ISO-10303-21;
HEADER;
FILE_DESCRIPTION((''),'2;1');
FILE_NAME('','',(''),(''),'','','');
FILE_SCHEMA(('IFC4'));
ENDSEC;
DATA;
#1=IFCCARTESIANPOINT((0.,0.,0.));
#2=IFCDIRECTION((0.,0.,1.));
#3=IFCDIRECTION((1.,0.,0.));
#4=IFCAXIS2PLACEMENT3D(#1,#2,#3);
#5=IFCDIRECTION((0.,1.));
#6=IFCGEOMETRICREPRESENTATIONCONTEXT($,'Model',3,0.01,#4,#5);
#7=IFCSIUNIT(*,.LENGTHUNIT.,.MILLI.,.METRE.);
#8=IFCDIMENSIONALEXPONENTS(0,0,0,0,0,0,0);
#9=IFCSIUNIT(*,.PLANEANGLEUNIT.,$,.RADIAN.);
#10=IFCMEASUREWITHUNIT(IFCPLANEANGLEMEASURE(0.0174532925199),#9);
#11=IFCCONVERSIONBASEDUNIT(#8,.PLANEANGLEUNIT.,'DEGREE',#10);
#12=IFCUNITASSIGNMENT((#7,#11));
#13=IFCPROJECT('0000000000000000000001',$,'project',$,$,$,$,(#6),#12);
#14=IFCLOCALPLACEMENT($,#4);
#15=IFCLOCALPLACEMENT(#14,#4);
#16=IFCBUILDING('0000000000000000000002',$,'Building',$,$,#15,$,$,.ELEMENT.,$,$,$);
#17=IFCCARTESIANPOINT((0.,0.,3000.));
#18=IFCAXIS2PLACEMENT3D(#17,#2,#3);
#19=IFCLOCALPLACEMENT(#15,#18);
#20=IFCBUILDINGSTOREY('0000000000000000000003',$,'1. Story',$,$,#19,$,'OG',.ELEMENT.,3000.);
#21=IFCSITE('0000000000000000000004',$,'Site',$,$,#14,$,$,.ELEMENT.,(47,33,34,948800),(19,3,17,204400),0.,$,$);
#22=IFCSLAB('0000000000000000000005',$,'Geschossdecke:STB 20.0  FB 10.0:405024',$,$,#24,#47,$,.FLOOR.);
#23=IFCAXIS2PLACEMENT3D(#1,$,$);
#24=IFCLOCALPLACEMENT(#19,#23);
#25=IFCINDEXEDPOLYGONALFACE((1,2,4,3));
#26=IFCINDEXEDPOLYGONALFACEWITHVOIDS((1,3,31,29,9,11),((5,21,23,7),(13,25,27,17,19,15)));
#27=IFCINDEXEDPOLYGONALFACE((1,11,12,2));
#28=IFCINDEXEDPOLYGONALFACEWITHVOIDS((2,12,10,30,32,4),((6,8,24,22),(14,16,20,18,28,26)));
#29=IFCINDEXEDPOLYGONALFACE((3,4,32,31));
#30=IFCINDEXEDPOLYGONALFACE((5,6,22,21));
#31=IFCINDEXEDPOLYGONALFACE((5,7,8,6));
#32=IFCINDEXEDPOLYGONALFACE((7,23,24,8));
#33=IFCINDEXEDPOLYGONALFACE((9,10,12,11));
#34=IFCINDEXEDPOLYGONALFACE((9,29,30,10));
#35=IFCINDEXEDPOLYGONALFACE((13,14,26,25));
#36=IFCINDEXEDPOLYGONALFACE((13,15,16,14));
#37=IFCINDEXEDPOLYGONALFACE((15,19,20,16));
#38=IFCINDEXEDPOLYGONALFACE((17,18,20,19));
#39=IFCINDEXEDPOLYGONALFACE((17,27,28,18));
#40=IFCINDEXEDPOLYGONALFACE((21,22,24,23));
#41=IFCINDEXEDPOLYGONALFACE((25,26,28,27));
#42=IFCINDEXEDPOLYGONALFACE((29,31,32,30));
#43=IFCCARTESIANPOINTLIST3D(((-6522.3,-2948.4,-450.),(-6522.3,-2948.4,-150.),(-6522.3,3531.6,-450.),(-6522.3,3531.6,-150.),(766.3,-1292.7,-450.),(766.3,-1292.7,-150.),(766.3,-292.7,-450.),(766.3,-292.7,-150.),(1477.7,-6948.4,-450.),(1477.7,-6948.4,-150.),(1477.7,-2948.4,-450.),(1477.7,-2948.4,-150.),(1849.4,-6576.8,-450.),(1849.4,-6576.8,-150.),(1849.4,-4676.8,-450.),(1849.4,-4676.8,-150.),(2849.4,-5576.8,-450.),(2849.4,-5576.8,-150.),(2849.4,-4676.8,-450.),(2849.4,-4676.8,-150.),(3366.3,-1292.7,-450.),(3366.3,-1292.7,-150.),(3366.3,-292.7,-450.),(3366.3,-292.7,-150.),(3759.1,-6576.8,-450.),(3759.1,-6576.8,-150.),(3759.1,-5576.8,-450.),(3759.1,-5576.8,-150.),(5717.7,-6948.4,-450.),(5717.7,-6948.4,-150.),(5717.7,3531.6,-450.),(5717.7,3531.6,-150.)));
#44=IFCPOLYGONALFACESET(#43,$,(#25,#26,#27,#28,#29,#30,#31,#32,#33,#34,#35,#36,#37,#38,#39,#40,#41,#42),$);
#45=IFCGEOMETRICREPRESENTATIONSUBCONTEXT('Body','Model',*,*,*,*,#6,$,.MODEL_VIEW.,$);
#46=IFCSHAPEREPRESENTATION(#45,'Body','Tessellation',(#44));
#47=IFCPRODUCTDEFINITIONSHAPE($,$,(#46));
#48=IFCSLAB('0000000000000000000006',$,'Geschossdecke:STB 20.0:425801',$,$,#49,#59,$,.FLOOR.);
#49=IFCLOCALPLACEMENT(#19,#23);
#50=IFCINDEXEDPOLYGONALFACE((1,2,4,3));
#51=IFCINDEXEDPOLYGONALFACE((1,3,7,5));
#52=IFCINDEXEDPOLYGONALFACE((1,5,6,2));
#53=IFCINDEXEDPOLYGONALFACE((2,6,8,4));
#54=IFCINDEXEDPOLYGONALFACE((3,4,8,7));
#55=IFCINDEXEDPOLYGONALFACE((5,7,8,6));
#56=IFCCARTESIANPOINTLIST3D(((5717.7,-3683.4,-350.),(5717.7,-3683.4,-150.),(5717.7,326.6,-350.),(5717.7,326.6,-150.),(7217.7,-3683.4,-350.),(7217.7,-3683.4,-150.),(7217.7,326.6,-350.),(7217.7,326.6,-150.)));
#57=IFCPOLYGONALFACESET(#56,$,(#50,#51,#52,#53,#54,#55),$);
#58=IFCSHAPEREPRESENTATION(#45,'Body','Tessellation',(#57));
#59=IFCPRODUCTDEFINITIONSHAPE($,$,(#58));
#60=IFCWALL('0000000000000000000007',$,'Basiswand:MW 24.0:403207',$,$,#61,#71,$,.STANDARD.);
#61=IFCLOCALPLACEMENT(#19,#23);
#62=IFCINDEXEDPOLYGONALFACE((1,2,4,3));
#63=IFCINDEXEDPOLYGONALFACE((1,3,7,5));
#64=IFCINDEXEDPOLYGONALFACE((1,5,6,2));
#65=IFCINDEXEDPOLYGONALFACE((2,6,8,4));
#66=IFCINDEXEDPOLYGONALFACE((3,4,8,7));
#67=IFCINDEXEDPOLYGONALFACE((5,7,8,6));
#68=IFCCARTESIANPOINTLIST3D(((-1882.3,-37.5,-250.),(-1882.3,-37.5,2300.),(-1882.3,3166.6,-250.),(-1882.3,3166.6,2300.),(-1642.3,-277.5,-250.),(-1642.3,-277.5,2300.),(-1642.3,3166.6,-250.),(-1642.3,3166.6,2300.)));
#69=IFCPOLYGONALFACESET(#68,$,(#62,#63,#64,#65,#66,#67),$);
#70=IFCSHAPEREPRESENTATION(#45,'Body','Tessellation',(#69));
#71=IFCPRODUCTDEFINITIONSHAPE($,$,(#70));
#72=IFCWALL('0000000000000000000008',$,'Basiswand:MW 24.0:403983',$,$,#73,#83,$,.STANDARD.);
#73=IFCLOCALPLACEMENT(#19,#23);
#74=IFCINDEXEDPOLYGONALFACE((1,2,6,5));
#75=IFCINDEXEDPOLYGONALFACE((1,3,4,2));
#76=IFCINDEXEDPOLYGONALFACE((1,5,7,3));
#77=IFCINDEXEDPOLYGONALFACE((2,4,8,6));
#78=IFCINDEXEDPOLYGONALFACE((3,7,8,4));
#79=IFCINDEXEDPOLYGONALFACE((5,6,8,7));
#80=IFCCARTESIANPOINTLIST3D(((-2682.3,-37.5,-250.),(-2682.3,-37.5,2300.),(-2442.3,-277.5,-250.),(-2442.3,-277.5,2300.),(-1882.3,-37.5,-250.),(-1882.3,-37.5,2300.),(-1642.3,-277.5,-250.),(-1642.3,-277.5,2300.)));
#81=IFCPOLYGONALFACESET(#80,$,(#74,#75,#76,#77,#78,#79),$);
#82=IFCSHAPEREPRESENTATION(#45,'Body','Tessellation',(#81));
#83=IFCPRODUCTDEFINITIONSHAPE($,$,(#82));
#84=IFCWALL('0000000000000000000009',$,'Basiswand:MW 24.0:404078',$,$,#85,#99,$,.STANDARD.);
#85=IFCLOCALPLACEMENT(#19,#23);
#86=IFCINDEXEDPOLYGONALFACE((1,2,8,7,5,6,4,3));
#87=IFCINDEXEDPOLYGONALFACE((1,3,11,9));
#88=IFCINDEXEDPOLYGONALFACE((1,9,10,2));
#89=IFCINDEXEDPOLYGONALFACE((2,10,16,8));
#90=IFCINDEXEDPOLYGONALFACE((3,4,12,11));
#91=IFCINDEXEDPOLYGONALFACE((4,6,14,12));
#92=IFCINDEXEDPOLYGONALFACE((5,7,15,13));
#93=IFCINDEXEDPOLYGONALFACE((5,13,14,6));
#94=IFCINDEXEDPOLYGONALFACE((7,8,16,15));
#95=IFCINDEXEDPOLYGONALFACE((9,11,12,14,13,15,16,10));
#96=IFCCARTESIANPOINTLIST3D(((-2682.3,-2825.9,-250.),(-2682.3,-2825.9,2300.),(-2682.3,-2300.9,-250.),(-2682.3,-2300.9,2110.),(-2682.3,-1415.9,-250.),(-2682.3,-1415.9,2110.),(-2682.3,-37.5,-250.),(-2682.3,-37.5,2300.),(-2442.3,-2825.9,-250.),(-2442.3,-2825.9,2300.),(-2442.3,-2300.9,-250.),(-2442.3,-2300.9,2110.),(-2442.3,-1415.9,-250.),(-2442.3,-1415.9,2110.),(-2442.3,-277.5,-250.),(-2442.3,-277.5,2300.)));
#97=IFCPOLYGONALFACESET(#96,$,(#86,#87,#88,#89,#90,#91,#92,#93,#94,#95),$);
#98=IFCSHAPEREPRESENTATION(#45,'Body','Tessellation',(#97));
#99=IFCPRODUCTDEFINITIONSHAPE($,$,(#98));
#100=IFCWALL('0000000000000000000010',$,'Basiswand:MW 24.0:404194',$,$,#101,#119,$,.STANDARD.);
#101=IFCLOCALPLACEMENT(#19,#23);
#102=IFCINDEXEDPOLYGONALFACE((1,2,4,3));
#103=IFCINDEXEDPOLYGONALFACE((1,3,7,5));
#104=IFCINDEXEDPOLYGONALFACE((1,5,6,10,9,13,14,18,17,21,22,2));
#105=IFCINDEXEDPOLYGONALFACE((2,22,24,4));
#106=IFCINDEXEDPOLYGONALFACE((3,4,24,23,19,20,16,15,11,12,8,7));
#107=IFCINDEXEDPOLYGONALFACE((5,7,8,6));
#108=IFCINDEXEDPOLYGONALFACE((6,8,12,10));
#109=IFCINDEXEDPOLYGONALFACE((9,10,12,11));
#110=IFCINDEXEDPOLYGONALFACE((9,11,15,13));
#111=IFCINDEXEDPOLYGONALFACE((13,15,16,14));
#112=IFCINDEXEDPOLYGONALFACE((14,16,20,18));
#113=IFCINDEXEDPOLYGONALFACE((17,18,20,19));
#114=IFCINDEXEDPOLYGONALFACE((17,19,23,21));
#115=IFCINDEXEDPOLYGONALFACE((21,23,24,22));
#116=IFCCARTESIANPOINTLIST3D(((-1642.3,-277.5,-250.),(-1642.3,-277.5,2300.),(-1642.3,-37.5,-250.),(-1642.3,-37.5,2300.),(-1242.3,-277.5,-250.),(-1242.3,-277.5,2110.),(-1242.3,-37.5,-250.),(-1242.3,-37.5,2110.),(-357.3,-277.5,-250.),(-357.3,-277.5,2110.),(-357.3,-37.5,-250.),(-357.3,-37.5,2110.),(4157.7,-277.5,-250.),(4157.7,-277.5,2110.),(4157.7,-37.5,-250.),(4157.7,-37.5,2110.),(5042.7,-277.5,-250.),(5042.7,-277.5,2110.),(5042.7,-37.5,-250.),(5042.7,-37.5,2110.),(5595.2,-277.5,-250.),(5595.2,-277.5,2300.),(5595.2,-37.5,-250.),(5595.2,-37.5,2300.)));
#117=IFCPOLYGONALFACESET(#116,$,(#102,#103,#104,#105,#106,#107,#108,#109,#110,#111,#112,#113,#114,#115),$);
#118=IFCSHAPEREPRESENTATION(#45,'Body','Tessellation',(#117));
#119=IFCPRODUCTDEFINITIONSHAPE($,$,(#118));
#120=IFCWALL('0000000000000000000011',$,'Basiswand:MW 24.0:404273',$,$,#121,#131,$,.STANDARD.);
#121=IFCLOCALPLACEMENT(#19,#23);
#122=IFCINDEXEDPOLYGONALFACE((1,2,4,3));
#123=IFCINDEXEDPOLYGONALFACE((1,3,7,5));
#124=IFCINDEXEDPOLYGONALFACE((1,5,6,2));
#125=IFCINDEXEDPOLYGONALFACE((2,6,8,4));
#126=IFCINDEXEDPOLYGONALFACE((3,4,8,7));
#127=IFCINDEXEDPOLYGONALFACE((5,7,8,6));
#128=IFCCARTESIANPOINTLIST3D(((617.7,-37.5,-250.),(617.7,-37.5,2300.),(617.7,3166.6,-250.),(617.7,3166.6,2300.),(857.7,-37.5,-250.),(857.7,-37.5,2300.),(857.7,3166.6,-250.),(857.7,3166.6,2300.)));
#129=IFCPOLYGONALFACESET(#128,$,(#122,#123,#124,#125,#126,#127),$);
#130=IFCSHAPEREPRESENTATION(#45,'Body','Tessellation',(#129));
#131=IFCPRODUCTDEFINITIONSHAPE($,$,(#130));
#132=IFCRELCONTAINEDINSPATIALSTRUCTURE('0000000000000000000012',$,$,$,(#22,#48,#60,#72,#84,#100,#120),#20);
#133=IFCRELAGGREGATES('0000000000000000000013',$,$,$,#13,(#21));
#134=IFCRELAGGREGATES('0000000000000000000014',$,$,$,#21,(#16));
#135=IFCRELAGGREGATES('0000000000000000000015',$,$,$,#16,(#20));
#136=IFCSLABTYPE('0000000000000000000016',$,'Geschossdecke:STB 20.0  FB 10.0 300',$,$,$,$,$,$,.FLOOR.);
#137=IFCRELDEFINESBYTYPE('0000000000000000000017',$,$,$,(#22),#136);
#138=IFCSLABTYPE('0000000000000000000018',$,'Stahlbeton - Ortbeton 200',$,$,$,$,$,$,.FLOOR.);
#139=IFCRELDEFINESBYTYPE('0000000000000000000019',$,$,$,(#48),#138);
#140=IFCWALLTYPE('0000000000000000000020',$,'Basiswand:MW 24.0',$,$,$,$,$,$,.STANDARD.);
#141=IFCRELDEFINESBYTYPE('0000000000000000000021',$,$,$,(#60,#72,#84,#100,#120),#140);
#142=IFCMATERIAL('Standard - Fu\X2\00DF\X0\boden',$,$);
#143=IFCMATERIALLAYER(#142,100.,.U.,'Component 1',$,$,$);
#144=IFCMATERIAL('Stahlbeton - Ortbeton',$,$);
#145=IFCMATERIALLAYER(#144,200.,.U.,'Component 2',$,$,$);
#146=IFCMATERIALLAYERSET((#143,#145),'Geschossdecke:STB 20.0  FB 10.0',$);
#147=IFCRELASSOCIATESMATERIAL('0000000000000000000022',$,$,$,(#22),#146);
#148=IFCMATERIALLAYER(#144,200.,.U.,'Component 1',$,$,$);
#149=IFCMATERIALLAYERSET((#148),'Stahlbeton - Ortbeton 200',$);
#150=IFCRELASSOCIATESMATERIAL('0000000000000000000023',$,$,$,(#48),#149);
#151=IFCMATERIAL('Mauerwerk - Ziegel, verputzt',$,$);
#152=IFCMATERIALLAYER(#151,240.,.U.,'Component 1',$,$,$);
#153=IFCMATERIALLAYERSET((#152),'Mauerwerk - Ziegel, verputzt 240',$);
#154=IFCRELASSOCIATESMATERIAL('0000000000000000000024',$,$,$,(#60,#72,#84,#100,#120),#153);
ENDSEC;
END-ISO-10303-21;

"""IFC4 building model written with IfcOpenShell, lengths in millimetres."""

from ifc_helpers import new_model, entity, si_unit, converted_unit, direction, frame, origin_with_axes, origin_2d_with_axis, place, context, subcontext, project, spatial, line, indexed_curve, rectangle, outline, extrude, material, layer, layer_set, layer_usage, type_object, element, save


model = new_model("IFC4")

# Units and contexts
model_context = context("Model", 3, precision=0.01, world=origin_with_axes(), true_north=direction((0.0, 1.0)))
body_context = subcontext(model_context, "Body", "Model", "MODEL_VIEW")
ifc_project = project(units=[si_unit("LENGTHUNIT", "METRE", prefix="MILLI"), converted_unit("PLANEANGLEUNIT", "DEGREE", entity("IfcPlaneAngleMeasure", 0.0174532925199), si_unit("PLANEANGLEUNIT", "RADIAN"), dimensions=[0, 0, 0, 0, 0, 0, 0])], contexts=[model_context])

# Site, building, storey
site_placement = place(None, origin_with_axes())
site = spatial("IfcSite", under=ifc_project, at=site_placement, Name="Site", CompositionType="ELEMENT", RefLatitude=(47, 33, 34, 948800), RefLongitude=(19, 3, 17, 204400), RefElevation=0.0)
building_placement = place(site_placement, origin_with_axes())
building = spatial("IfcBuilding", under=site, at=building_placement, Name="Building", CompositionType="ELEMENT")
storey_placement = place(building_placement, frame((0.0, 0.0, 3000.0), z_axis=(0.0, 0.0, 1.0), x_axis=(1.0, 0.0, 0.0)))
storey = spatial("IfcBuildingStorey", under=building, at=storey_placement, Name="1. Story", LongName="OG", CompositionType="ELEMENT", Elevation=3000.0)

# Slab, openings
ifc_material_1 = material(Name="Standard - Fußboden")
ifc_layer_1 = layer(ifc_material_1, 100.0, ventilated="UNKNOWN", Name="Component 1")
ifc_material_2 = material(Name="Stahlbeton - Ortbeton")
ifc_layer_2 = layer(ifc_material_2, 200.0, ventilated="UNKNOWN", Name="Component 2")
ifc_layer_set_1 = layer_set([ifc_layer_1, ifc_layer_2], Name="Geschossdecke:STB 20.0  FB 10.0")
ifc_layer_usage_1 = layer_usage(ifc_layer_set_1, "AXIS3", "NEGATIVE", 300.0)
slab_type_1 = type_object("IfcSlabType", Name="Geschossdecke:STB 20.0  FB 10.0 300", PredefinedType="FLOOR")
slab_1_placement = place(storey_placement, frame((-6522.3, 3531.6, -450.0), z_axis=(0.0, 0.0, 1.0), x_axis=(1.0, 0.0, 0.0)))
slab_1 = element("IfcSlab", 1, at=slab_1_placement, inside=storey, type_object=slab_type_1, material=ifc_layer_usage_1, Name="Geschossdecke:STB 20.0  FB 10.0:405024", PredefinedType="FLOOR", context=body_context, shape_type="SweptSolid", body=[
    extrude(outline(indexed_curve([(0.0, 0.0), (0.0, -6480.0), (8000.0, -6480.0), (8000.0, -10480.0), (12240.0, -10480.0), (12240.0, 0.0)], segments=[line(1, 2, 3, 4, 5, 6, 1)])), origin_with_axes(), (0.0, 0.0, 1.0), 300.0),
])
opening_1_placement = place(slab_1_placement, frame((8371.7, -8208.3, 0.0), z_axis=(0.0, 0.0, 1.0), x_axis=(0.0, -1.0, 0.0)))
element("IfcOpeningElement", 2, at=opening_1_placement, cuts=slab_1, context=body_context, shape_type="SweptSolid", body=[
    extrude(outline(indexed_curve([(0.0, 0.0), (1900.0, 0.0), (1900.0, 1909.7), (900.0, 1909.7), (900.0, 1000.0), (0.0, 1000.0)], segments=[line(1, 2, 3, 4, 5, 6, 1)])), origin_with_axes(), (0.0, 0.0, 1.0), 300.0),
])
opening_2_placement = place(slab_1_placement, frame((6522.3, -3531.6, -2550.0), z_axis=(0.0, 0.0, 1.0), x_axis=(1.0, 0.0, 0.0)))
element("IfcOpeningElement", 3, at=opening_2_placement, cuts=slab_1, PredefinedType="OPENING", context=body_context, shape_type="SweptSolid", body=[
    extrude(rectangle(XDim=2600.0, YDim=1000.0, at=origin_2d_with_axis()), frame((2066.3, -792.7, 2850.0), z_axis=(0.0, 0.0, -1.0), x_axis=(1.0, 0.0, 0.0)), (0.0, 0.0, 1.0), 300.0),
])

# Slab
ifc_layer_3 = layer(ifc_material_2, 200.0, ventilated="UNKNOWN", Name="Component 1")
ifc_layer_set_2 = layer_set([ifc_layer_3], Name="Stahlbeton - Ortbeton 200")
ifc_layer_usage_2 = layer_usage(ifc_layer_set_2, "AXIS3", "NEGATIVE", 200.0)
slab_type_2 = type_object("IfcSlabType", Name="Stahlbeton - Ortbeton 200", PredefinedType="FLOOR")
slab_2_placement = place(storey_placement, frame((7217.7, 326.6, -150.0), z_axis=(0.0, 0.0, 1.0), x_axis=(1.0, 0.0, 0.0)))
element("IfcSlab", 4, at=slab_2_placement, inside=storey, type_object=slab_type_2, material=ifc_layer_usage_2, Name="Geschossdecke:STB 20.0:425801", PredefinedType="FLOOR", context=body_context, shape_type="SweptSolid", body=[
    extrude(outline(indexed_curve([(0.0, 0.0), (-1500.0, 0.0), (-1500.0, -4010.0), (0.0, -4010.0)], segments=[line(1, 2, 3, 4, 1)])), frame((0.0, 0.0, -200.0), z_axis=(0.0, 0.0, 1.0), x_axis=(1.0, 0.0, 0.0)), (0.0, 0.0, 1.0), 200.0),
])

# Walls
ifc_material_3 = material(Name="Mauerwerk - Ziegel, verputzt")
ifc_layer_4 = layer(ifc_material_3, 240.0, ventilated="UNKNOWN", Name="Component 1")
ifc_layer_set_3 = layer_set([ifc_layer_4], Name="Mauerwerk - Ziegel, verputzt 240")
ifc_layer_usage_3 = layer_usage(ifc_layer_set_3, "AXIS2", "POSITIVE", -120.0)
wall_type = type_object("IfcWallType", Name="Basiswand:MW 24.0", PredefinedType="STANDARD")
wall_1_placement = place(storey_placement, frame((-1762.3, 3166.6, -250.0), z_axis=(0.0, 0.0, 1.0), x_axis=(0.0, -1.0, 0.0)))
element("IfcWall", 5, at=wall_1_placement, inside=storey, type_object=wall_type, material=ifc_layer_usage_3, Name="Basiswand:MW 24.0:403207", PredefinedType="STANDARD", context=body_context, shape_type="SweptSolid", body=[
    extrude(outline(indexed_curve([(0.0, -120.0), (3204.1, -120.0), (3444.1, 120.0), (0.0, 120.0)], segments=[line(1, 2, 3, 4, 1)])), origin_with_axes(), (0.0, 0.0, 1.0), 2550.0),
])
ifc_layer_usage_4 = layer_usage(ifc_layer_set_3, "AXIS2", "POSITIVE", -120.0)
wall_2_placement = place(storey_placement, frame((-1762.3, -157.5, -250.0), z_axis=(0.0, 0.0, 1.0), x_axis=(-1.0, 0.0, 0.0)))
element("IfcWall", 6, at=wall_2_placement, inside=storey, type_object=wall_type, material=ifc_layer_usage_4, Name="Basiswand:MW 24.0:403983", PredefinedType="STANDARD", context=body_context, shape_type="SweptSolid", body=[
    extrude(outline(indexed_curve([(120.0, -120.0), (920.0, -120.0), (680.0, 120.0), (-120.0, 120.0)], segments=[line(1, 2, 3, 4, 1)])), origin_with_axes(), (0.0, 0.0, 1.0), 2550.0),
])

# Wall, opening
ifc_layer_usage_5 = layer_usage(ifc_layer_set_3, "AXIS2", "POSITIVE", -120.0)
wall_3_placement = place(storey_placement, frame((-2562.3, -157.5, -250.0), z_axis=(0.0, 0.0, 1.0), x_axis=(0.0, -1.0, 0.0)))
wall_3 = element("IfcWall", 7, at=wall_3_placement, inside=storey, type_object=wall_type, material=ifc_layer_usage_5, Name="Basiswand:MW 24.0:404078", PredefinedType="STANDARD", context=body_context, shape_type="SweptSolid", body=[
    extrude(outline(indexed_curve([(-120.0, -120.0), (2668.4, -120.0), (2668.4, 120.0), (120.0, 120.0)], segments=[line(1, 2, 3, 4, 1)])), origin_with_axes(), (0.0, 0.0, 1.0), 2550.0),
])
opening_3_placement = place(wall_3_placement, frame((1700.9, 0.0, 0.0), z_axis=(0.0, 0.0, 1.0), x_axis=(1.0, 0.0, 0.0)))
element("IfcOpeningElement", 8, at=opening_3_placement, cuts=wall_3, context=body_context, shape_type="SweptSolid", body=[
    extrude(outline(indexed_curve([(-442.5, -2360.0), (442.5, -2360.0), (442.5, 0.0), (-442.5, 0.0)], segments=[line(1, 2, 3, 4, 1)])), frame((0.0, 120.0, 0.0), z_axis=(0.0, -1.0, 0.0), x_axis=(-1.0, 0.0, 0.0)), (0.0, 0.0, 1.0), 240.0),
])

# Wall, openings
ifc_layer_usage_6 = layer_usage(ifc_layer_set_3, "AXIS2", "POSITIVE", -120.0)
wall_4_placement = place(storey_placement, frame((-1762.3, -157.5, -250.0), z_axis=(0.0, 0.0, 1.0), x_axis=(1.0, 0.0, 0.0)))
wall_4 = element("IfcWall", 9, at=wall_4_placement, inside=storey, type_object=wall_type, material=ifc_layer_usage_6, Name="Basiswand:MW 24.0:404194", PredefinedType="STANDARD", context=body_context, shape_type="SweptSolid", body=[
    extrude(outline(indexed_curve([(120.0, -120.0), (7357.5, -120.0), (7357.5, 120.0), (120.0, 120.0)], segments=[line(1, 2, 3, 4, 1)])), origin_with_axes(), (0.0, 0.0, 1.0), 2550.0),
])
opening_4_placement = place(wall_4_placement, frame((6362.5, 0.0, 0.0), z_axis=(0.0, 0.0, 1.0), x_axis=(1.0, 0.0, 0.0)))
element("IfcOpeningElement", 10, at=opening_4_placement, cuts=wall_4, context=body_context, shape_type="SweptSolid", body=[
    extrude(outline(indexed_curve([(-442.5, -2360.0), (442.5, -2360.0), (442.5, 0.0), (-442.5, 0.0)], segments=[line(1, 2, 3, 4, 1)])), frame((0.0, -120.0, 0.0), z_axis=(0.0, 1.0, 0.0), x_axis=(1.0, 0.0, 0.0)), (0.0, 0.0, 1.0), 240.0),
])
opening_5_placement = place(wall_4_placement, frame((962.5, 0.0, 0.0), z_axis=(0.0, 0.0, 1.0), x_axis=(1.0, 0.0, 0.0)))
element("IfcOpeningElement", 11, at=opening_5_placement, cuts=wall_4, context=body_context, shape_type="SweptSolid", body=[
    extrude(outline(indexed_curve([(-442.5, -2360.0), (442.5, -2360.0), (442.5, 0.0), (-442.5, 0.0)], segments=[line(1, 2, 3, 4, 1)])), frame((0.0, -120.0, 0.0), z_axis=(0.0, 1.0, 0.0), x_axis=(1.0, 0.0, 0.0)), (0.0, 0.0, 1.0), 240.0),
])

# Wall
ifc_layer_usage_7 = layer_usage(ifc_layer_set_3, "AXIS2", "POSITIVE", -120.0)
wall_5_placement = place(storey_placement, frame((737.7, 3166.6, -250.0), z_axis=(0.0, 0.0, 1.0), x_axis=(0.0, -1.0, 0.0)))
element("IfcWall", 12, at=wall_5_placement, inside=storey, type_object=wall_type, material=ifc_layer_usage_7, Name="Basiswand:MW 24.0:404273", PredefinedType="STANDARD", context=body_context, shape_type="SweptSolid", body=[
    extrude(outline(indexed_curve([(0.0, -120.0), (3204.1, -120.0), (3204.1, 120.0), (0.0, 120.0)], segments=[line(1, 2, 3, 4, 1)])), origin_with_axes(), (0.0, 0.0, 1.0), 2550.0),
])

save(model, "model.ifc")
